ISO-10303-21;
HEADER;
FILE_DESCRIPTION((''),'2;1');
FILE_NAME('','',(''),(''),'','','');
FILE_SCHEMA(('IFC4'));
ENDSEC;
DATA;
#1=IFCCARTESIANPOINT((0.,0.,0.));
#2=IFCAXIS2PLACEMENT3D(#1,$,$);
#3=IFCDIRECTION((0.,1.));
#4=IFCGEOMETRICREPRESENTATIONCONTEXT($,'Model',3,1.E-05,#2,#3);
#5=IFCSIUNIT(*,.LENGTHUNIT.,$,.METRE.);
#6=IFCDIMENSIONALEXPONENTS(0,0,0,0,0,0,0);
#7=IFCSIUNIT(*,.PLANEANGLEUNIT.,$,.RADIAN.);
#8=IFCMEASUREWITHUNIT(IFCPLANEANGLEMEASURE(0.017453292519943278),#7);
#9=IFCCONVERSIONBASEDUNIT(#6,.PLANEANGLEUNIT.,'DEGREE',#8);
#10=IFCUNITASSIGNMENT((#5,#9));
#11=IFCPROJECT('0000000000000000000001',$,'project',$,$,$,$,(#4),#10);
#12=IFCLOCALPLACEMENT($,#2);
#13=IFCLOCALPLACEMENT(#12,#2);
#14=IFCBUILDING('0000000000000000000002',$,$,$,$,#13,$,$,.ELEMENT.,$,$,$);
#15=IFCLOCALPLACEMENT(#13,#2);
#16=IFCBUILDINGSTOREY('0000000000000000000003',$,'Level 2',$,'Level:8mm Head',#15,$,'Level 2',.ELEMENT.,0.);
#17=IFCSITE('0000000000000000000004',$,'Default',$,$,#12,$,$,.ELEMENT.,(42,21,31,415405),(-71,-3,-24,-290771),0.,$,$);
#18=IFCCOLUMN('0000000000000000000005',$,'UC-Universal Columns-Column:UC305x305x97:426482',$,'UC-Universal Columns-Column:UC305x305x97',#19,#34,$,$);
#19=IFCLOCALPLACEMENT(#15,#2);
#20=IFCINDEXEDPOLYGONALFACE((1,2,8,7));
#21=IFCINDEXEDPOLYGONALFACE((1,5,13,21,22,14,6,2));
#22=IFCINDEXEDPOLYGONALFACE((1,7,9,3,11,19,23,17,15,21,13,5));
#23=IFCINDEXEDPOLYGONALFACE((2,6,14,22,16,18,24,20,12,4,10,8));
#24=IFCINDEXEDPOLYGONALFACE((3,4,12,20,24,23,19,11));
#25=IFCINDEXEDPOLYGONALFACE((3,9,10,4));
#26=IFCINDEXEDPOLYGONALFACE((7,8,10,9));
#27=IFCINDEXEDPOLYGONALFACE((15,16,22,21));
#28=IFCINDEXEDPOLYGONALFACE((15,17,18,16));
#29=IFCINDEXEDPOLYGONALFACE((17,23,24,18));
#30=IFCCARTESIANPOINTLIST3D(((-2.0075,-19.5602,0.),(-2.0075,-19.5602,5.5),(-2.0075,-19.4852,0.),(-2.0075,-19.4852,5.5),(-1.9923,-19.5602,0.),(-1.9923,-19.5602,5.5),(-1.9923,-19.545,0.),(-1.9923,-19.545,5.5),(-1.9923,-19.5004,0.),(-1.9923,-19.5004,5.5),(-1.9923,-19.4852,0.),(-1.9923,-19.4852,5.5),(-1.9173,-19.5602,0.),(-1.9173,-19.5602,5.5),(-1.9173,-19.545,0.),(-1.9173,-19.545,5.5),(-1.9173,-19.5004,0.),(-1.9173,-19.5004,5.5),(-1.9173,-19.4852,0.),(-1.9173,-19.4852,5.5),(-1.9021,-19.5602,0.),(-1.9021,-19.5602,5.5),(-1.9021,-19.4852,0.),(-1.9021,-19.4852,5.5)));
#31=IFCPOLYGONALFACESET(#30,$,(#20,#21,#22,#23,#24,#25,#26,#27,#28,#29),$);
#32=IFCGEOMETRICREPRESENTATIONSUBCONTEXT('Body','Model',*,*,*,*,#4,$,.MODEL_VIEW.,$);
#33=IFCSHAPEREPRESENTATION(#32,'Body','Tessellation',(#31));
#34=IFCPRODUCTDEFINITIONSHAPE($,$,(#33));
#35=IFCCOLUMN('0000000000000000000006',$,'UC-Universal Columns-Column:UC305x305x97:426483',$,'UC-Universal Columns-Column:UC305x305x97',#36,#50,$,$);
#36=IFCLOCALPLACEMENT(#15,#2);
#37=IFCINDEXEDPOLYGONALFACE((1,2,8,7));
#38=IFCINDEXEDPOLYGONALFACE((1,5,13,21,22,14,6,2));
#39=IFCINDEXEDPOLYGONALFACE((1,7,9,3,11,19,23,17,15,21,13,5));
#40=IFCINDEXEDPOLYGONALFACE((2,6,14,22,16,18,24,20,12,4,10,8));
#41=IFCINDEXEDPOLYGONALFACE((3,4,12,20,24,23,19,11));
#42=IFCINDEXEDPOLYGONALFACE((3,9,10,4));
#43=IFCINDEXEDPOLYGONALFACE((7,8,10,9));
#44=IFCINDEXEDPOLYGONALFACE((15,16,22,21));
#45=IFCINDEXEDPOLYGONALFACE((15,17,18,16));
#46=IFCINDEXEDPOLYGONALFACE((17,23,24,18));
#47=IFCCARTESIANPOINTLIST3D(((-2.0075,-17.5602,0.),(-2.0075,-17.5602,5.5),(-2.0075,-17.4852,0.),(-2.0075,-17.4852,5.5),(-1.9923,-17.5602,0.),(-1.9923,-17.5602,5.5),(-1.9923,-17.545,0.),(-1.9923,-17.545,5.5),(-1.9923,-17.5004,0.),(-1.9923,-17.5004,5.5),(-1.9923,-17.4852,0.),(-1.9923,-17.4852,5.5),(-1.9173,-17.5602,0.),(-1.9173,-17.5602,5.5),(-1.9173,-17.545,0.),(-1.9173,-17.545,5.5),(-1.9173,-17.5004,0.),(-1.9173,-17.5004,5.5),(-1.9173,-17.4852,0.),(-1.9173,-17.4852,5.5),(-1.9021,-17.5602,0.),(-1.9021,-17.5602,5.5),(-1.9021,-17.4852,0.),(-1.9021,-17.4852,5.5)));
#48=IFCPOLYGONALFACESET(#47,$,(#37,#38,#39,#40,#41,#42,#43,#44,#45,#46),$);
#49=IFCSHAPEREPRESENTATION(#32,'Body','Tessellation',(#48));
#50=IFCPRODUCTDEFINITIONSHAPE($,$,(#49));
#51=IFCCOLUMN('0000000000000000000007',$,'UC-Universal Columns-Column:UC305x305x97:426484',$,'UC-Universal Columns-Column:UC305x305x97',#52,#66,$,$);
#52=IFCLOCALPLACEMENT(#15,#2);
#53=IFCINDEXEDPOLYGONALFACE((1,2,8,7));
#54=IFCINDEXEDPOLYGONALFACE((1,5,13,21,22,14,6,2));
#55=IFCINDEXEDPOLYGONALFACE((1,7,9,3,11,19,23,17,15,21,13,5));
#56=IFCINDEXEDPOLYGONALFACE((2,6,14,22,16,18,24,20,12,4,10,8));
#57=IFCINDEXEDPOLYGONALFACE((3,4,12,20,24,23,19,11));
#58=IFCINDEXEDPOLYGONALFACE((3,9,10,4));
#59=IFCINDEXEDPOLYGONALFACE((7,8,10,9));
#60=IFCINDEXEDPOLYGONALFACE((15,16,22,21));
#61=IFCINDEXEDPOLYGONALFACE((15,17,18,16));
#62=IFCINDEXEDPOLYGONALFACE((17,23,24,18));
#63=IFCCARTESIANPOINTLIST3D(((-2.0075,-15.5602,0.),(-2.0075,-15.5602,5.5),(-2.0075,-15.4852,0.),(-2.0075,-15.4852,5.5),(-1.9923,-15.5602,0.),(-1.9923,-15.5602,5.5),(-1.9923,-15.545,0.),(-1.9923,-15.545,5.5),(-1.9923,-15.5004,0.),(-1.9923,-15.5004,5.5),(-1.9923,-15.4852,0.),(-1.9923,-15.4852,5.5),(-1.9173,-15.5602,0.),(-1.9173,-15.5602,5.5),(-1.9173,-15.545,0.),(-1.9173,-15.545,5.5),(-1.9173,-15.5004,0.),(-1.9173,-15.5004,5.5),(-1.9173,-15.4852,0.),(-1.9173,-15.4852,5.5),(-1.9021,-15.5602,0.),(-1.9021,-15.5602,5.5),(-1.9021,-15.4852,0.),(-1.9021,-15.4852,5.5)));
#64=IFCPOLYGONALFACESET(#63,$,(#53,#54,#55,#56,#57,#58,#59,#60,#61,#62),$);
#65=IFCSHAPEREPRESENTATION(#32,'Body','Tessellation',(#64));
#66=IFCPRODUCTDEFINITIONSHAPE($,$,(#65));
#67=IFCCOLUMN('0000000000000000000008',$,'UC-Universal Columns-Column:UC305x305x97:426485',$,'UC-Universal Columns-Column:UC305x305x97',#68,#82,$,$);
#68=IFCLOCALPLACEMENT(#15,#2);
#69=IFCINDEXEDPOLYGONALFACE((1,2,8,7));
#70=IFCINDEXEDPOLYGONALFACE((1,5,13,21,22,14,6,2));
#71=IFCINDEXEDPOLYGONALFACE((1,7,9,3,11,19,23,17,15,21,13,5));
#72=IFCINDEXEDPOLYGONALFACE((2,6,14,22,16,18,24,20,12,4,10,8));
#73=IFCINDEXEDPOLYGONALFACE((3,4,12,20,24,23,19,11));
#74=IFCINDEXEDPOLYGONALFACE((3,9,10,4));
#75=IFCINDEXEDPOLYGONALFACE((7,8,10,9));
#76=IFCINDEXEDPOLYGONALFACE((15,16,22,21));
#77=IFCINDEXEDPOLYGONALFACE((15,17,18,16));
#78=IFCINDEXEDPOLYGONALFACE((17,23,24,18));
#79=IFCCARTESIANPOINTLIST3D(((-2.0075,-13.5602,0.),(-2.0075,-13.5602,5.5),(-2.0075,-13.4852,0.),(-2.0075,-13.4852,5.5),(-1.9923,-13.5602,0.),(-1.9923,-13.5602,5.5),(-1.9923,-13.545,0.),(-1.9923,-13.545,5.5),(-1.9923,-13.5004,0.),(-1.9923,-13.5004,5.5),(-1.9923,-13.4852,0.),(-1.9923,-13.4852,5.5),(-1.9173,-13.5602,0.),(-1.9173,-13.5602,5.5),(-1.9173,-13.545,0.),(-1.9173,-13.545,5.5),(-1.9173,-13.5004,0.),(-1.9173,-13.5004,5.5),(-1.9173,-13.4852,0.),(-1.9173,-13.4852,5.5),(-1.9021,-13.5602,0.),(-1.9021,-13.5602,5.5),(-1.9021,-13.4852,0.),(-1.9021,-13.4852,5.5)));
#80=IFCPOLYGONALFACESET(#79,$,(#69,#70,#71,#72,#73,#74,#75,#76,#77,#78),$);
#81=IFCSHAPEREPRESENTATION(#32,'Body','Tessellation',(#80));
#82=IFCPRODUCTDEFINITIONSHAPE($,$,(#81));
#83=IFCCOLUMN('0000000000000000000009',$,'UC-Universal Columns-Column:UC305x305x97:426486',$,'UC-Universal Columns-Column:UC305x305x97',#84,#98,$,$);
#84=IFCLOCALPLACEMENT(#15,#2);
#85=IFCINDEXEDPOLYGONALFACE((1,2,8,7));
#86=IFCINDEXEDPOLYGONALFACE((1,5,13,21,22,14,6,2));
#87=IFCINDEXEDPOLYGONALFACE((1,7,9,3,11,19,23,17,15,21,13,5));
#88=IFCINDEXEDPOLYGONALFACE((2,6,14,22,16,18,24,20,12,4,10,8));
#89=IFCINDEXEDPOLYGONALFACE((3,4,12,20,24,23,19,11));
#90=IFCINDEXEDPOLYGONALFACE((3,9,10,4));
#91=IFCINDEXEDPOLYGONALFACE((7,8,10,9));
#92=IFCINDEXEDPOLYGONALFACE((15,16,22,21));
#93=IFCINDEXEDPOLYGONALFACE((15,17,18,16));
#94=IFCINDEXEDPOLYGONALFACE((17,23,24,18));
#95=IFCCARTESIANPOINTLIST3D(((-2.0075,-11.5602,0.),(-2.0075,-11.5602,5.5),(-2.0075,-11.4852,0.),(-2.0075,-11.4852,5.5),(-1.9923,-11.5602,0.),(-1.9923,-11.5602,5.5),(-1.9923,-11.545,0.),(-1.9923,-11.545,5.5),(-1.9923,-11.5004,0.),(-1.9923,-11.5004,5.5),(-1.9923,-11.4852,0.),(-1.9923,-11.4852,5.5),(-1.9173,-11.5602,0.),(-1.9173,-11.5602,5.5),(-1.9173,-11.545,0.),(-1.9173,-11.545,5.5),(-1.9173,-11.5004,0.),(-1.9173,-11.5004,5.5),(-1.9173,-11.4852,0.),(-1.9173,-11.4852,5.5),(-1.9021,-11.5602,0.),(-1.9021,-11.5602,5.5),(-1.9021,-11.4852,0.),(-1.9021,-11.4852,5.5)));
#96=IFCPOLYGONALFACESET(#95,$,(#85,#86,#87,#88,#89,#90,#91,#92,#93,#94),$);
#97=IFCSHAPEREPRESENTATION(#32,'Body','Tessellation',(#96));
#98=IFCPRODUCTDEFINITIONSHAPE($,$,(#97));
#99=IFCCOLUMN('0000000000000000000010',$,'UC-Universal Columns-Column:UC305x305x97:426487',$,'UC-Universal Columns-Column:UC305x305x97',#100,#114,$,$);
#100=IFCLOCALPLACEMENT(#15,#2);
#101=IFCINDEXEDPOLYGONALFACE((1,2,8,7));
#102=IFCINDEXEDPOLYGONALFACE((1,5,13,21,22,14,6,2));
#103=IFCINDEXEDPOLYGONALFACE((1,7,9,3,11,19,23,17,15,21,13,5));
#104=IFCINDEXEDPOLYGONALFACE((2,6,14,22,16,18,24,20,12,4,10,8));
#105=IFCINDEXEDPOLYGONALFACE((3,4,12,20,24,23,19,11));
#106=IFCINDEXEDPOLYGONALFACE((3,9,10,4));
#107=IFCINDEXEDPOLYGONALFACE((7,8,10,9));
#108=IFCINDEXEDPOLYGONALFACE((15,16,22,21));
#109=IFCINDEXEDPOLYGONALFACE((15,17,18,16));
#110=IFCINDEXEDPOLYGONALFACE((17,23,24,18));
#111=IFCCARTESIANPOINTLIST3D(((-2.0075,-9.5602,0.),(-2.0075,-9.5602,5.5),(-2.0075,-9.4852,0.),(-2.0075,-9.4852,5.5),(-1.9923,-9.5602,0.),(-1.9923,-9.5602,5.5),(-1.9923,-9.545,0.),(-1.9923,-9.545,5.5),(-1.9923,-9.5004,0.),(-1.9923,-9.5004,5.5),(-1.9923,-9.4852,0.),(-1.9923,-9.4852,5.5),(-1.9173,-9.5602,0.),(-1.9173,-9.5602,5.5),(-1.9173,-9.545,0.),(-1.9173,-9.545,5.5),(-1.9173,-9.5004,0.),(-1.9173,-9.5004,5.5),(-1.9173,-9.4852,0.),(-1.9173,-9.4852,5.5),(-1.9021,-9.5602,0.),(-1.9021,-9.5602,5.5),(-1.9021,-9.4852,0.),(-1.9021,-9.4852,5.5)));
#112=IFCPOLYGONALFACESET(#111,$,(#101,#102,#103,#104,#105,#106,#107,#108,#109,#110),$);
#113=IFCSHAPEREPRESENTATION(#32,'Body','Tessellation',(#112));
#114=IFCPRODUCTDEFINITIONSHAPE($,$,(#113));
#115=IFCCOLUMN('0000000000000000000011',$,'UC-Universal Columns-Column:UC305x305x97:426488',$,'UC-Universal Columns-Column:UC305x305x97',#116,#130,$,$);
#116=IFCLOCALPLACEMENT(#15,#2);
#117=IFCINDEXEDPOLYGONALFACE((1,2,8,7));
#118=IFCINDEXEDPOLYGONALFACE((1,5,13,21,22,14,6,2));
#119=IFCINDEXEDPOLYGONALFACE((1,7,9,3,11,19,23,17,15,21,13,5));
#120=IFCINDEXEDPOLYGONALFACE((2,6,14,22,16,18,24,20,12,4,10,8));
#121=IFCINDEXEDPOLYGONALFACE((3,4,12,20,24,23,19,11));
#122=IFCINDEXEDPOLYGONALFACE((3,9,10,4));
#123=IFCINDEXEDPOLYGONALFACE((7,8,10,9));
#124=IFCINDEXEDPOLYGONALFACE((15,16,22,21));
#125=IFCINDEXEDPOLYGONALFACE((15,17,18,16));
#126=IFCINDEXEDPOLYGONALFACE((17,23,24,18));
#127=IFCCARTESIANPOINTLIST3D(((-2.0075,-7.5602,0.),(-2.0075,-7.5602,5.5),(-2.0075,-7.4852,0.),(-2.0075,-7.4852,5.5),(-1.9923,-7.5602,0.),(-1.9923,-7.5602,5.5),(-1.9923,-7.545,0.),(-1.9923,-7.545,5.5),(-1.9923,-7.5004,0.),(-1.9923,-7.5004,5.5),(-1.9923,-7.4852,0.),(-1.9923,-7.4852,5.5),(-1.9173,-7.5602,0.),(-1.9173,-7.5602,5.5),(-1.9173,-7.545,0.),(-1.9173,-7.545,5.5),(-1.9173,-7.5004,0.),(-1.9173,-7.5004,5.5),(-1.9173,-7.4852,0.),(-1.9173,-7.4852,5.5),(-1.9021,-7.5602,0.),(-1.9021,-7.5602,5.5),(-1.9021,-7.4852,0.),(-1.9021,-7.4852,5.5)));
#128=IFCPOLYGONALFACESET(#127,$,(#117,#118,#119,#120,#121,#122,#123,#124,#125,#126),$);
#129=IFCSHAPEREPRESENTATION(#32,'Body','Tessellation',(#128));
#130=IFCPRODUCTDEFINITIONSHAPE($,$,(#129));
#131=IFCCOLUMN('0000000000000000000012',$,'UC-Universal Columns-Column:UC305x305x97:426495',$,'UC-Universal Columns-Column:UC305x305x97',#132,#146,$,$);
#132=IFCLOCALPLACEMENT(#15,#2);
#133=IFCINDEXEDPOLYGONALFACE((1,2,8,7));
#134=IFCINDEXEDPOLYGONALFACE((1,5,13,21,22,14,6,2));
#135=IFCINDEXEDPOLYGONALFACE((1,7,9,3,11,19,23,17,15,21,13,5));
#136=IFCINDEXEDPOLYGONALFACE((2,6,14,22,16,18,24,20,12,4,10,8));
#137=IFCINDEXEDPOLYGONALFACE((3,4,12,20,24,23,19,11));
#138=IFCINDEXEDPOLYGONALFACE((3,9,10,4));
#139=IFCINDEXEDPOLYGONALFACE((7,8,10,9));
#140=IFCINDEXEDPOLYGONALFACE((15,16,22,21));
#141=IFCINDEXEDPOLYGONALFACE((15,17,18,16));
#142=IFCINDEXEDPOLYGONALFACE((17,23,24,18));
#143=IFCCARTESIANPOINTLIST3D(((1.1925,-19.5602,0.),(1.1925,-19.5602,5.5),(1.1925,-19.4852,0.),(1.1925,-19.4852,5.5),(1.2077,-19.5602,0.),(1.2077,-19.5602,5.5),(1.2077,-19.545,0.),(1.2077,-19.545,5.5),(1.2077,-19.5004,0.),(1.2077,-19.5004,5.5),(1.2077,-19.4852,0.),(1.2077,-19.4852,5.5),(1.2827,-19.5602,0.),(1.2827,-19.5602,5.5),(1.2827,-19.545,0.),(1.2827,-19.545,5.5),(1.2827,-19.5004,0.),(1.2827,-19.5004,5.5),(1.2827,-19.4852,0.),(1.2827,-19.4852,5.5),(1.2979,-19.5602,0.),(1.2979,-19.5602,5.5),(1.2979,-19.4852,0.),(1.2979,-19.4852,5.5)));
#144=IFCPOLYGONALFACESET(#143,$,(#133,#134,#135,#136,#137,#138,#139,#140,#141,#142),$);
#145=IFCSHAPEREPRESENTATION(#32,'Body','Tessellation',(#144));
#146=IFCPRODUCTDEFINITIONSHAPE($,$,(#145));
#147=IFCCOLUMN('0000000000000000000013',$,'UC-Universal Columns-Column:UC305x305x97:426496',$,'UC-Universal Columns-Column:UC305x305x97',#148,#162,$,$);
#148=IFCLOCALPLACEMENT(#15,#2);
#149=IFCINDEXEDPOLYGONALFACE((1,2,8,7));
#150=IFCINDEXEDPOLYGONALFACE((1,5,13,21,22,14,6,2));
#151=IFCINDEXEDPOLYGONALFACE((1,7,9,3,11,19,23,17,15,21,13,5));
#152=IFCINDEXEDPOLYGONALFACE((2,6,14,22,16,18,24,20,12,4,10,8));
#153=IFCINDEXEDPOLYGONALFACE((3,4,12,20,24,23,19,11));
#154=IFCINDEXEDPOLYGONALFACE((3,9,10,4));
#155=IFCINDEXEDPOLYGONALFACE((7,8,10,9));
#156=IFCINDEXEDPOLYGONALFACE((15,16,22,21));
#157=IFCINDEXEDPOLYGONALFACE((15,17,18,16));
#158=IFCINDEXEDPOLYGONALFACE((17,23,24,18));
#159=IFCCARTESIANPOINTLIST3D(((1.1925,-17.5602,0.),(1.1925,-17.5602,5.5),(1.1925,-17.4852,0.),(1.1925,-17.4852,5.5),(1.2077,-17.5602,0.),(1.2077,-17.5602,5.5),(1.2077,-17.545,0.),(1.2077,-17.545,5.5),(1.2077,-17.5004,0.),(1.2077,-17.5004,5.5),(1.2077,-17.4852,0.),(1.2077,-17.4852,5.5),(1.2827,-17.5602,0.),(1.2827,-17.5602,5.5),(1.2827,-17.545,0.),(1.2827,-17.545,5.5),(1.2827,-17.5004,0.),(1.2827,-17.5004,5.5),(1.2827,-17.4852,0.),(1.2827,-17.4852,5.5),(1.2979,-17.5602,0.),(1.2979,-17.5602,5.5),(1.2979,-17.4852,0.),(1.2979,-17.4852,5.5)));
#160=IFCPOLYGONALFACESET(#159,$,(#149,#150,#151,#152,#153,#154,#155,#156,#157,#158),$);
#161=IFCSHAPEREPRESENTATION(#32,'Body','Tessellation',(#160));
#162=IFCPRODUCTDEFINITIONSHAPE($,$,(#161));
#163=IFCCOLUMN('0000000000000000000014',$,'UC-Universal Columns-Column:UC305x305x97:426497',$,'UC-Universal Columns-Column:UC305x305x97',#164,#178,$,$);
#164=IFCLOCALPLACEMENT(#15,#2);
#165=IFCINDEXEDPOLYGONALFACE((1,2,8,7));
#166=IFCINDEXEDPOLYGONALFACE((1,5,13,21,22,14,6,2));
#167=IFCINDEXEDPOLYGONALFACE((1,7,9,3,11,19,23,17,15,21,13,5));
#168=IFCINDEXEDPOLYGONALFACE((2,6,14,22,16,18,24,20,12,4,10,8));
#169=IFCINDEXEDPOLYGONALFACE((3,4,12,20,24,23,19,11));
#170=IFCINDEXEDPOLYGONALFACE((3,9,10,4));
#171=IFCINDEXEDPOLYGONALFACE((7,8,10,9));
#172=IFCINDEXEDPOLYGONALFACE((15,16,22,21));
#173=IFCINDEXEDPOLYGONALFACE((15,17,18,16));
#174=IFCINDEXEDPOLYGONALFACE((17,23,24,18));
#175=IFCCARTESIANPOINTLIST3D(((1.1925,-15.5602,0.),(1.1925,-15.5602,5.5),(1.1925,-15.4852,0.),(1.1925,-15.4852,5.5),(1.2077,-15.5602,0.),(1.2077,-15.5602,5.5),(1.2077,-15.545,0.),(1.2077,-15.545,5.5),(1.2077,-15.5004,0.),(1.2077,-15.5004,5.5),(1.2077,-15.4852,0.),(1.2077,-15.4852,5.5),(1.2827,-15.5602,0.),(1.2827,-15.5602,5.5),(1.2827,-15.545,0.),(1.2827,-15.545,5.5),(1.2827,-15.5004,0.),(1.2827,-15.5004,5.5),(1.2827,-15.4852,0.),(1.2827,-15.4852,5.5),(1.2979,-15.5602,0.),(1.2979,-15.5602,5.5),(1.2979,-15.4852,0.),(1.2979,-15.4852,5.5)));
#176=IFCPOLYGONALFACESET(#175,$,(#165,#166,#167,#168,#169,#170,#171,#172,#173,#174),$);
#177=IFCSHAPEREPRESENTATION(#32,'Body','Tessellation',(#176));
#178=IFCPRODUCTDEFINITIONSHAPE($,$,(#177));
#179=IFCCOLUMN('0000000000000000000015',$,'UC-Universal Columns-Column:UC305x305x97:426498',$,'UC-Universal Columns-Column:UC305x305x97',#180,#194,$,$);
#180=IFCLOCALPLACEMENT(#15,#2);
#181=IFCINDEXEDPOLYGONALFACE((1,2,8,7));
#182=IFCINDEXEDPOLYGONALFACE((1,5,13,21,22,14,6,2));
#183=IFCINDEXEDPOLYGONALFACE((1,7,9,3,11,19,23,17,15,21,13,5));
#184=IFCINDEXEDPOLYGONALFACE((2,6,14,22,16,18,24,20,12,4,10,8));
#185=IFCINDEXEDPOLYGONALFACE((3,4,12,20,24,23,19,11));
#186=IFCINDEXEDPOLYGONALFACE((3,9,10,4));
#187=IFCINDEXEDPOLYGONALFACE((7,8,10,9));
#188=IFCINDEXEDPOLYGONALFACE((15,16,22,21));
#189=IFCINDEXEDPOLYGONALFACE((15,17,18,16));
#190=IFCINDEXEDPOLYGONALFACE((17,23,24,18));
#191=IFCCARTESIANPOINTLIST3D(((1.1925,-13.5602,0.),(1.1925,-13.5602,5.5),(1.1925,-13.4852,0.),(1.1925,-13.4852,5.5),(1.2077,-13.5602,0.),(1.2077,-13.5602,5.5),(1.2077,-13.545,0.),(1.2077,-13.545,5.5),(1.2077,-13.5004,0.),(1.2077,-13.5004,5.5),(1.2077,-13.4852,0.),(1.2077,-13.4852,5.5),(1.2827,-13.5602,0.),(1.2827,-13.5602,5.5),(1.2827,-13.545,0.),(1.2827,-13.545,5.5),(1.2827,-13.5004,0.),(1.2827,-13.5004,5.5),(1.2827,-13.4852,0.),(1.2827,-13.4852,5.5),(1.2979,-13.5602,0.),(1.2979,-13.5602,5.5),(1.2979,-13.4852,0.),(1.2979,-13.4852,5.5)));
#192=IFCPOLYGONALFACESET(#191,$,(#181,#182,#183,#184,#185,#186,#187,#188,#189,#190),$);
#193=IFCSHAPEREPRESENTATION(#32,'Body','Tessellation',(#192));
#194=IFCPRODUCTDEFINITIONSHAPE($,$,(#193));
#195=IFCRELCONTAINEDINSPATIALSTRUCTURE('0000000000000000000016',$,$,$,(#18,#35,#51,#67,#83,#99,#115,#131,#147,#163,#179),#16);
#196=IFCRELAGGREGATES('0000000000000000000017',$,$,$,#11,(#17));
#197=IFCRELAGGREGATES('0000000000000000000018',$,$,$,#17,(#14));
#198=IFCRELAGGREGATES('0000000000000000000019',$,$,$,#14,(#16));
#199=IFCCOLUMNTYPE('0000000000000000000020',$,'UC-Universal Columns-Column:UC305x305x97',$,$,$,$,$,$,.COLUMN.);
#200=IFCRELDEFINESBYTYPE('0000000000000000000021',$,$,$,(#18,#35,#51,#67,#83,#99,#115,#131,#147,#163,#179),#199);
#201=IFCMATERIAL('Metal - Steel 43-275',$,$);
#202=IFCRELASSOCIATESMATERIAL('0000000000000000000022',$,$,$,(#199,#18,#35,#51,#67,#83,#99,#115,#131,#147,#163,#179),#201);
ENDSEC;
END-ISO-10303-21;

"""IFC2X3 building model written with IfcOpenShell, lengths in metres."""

from ifc_helpers import new_model, entity, si_unit, converted_unit, direction, frame, frame_2d, origin, place, context, subcontext, project, spatial, polyline, circle_curve, parameter, trimmed, segment, composite_curve, outline, extrude, source, transform, mapped, material, type_object, type_shapes, element, save


model = new_model("IFC2X3")

# Units and contexts
model_context = context("Model", 3, precision=1e-05, world=origin(), true_north=direction((0.0, 1.0)))
body_context = subcontext(model_context, "Body", "Model", "MODEL_VIEW")
ifc_project = project(units=[si_unit("LENGTHUNIT", "METRE"), converted_unit("PLANEANGLEUNIT", "DEGREE", entity("IfcPlaneAngleMeasure", 0.017453292519943278), si_unit("PLANEANGLEUNIT", "RADIAN"), dimensions=[0, 0, 0, 0, 0, 0, 0])], contexts=[model_context])

# Site, building, storey
site_placement = place(None, origin())
site = spatial("IfcSite", under=ifc_project, at=site_placement, Name="Default", CompositionType="ELEMENT", RefLatitude=(42, 21, 31, 415405), RefLongitude=(-71, -3, -24, -290771), RefElevation=0.0)
building_placement = place(site_placement, origin())
building = spatial("IfcBuilding", under=site, at=building_placement, CompositionType="ELEMENT")
storey_placement = place(building_placement, origin())
storey = spatial("IfcBuildingStorey", under=building, at=storey_placement, Name="Level 2", ObjectType="Level:8mm Head", LongName="Level 2", CompositionType="ELEMENT", Elevation=0.0)

# Columns
ifc_material = material(Name="Metal - Steel 43-275")
column_type = type_object("IfcColumnType", Name="UC-Universal Columns-Column:UC305x305x97", PredefinedType="COLUMN", material=ifc_material)
shared_shape = source(origin(), body_context, "Body", "SweptSolid", [
    extrude(outline(composite_curve([segment(polyline([(-0.0375, -0.0375), (0.0375, -0.0375)]), True, "CONTINUOUS"), segment(polyline([(0.0375, -0.0375), (0.0527, -0.0375)]), True, "CONTINUOUS"), segment(trimmed(circle_curve(frame_2d((0.0527, -0.0223), x_axis=(-1.0, 0.0)), 0.0152), [parameter(0.0)], [parameter(90.0)], True, "PARAMETER"), False, "CONTINUOUS"), segment(polyline([(0.0375, -0.0223), (0.0375, 0.0223)]), True, "CONTINUOUS"), segment(trimmed(circle_curve(frame_2d((0.0527, 0.0223), x_axis=(-1.0, 0.0)), 0.0152), [parameter(270.0)], [parameter(0.0)], True, "PARAMETER"), False, "CONTINUOUS"), segment(polyline([(0.0527, 0.0375), (0.0375, 0.0375)]), True, "CONTINUOUS"), segment(polyline([(0.0375, 0.0375), (-0.0375, 0.0375)]), True, "CONTINUOUS"), segment(polyline([(-0.0375, 0.0375), (-0.0527, 0.0375)]), True, "CONTINUOUS"), segment(trimmed(circle_curve(frame_2d((-0.0527, 0.0223), x_axis=(-1.0, 0.0)), 0.0152), [parameter(180.0)], [parameter(270.0)], True, "PARAMETER"), False, "CONTINUOUS"), segment(polyline([(-0.0375, 0.0223), (-0.0375, -0.0223)]), True, "CONTINUOUS"), segment(trimmed(circle_curve(frame_2d((-0.0527, -0.0223), x_axis=(-1.0, 0.0)), 0.0152), [parameter(90.0)], [parameter(180.0)], True, "PARAMETER"), False, "CONTINUOUS"), segment(polyline([(-0.0527, -0.0375), (-0.0375, -0.0375)]), True, "CONTINUOUS")], self_intersect=False)), frame((0.0, 0.0, 0.0), z_axis=(0.0, 0.0, 1.0), x_axis=(-1.0, 0.0, 0.0)), (0.0, 0.0, 1.0), 5.5),
])
type_shapes(column_type, [shared_shape])
for number, where, z_axis, x_axis, name in (
    (1, (-1.9548, -19.5227, 0.0), (0.0, 0.0, 1.0), (-1.0, 0.0, 0.0), "UC-Universal Columns-Column:UC305x305x97:426482"),
    (2, (-1.9548, -17.5227, 0.0), (0.0, 0.0, 1.0), (-1.0, 0.0, 0.0), "UC-Universal Columns-Column:UC305x305x97:426483"),
    (3, (-1.9548, -15.5227, 0.0), (0.0, 0.0, 1.0), (-1.0, 0.0, 0.0), "UC-Universal Columns-Column:UC305x305x97:426484"),
    (4, (-1.9548, -13.5227, 0.0), (0.0, 0.0, 1.0), (-1.0, 0.0, 0.0), "UC-Universal Columns-Column:UC305x305x97:426485"),
    (5, (-1.9548, -11.5227, 0.0), (0.0, 0.0, 1.0), (-1.0, 0.0, 0.0), "UC-Universal Columns-Column:UC305x305x97:426486"),
    (6, (-1.9548, -9.5227, 0.0), (0.0, 0.0, 1.0), (-1.0, 0.0, 0.0), "UC-Universal Columns-Column:UC305x305x97:426487"),
    (7, (-1.9548, -7.5227, 0.0), (0.0, 0.0, 1.0), (-1.0, 0.0, 0.0), "UC-Universal Columns-Column:UC305x305x97:426488"),
    (8, (1.2452, -19.5227, 0.0), (0.0, 0.0, 1.0), (-1.0, 0.0, 0.0), "UC-Universal Columns-Column:UC305x305x97:426495"),
    (9, (1.2452, -17.5227, 0.0), (0.0, 0.0, 1.0), (-1.0, 0.0, 0.0), "UC-Universal Columns-Column:UC305x305x97:426496"),
    (10, (1.2452, -15.5227, 0.0), (0.0, 0.0, 1.0), (-1.0, 0.0, 0.0), "UC-Universal Columns-Column:UC305x305x97:426497"),
    (11, (1.2452, -13.5227, 0.0), (0.0, 0.0, 1.0), (-1.0, 0.0, 0.0), "UC-Universal Columns-Column:UC305x305x97:426498"),
):
    element("IfcColumn", number, at=place(storey_placement, frame(where, z_axis=z_axis, x_axis=x_axis)), inside=storey, type_object=column_type, material=ifc_material, Name=name, ObjectType="UC-Universal Columns-Column:UC305x305x97", context=body_context, shape_type="MappedRepresentation", body=[
        mapped(shared_shape, transform((0.0, 0.0, 0.0), scale=1.0)),
    ])

save(model, "model.ifc")
